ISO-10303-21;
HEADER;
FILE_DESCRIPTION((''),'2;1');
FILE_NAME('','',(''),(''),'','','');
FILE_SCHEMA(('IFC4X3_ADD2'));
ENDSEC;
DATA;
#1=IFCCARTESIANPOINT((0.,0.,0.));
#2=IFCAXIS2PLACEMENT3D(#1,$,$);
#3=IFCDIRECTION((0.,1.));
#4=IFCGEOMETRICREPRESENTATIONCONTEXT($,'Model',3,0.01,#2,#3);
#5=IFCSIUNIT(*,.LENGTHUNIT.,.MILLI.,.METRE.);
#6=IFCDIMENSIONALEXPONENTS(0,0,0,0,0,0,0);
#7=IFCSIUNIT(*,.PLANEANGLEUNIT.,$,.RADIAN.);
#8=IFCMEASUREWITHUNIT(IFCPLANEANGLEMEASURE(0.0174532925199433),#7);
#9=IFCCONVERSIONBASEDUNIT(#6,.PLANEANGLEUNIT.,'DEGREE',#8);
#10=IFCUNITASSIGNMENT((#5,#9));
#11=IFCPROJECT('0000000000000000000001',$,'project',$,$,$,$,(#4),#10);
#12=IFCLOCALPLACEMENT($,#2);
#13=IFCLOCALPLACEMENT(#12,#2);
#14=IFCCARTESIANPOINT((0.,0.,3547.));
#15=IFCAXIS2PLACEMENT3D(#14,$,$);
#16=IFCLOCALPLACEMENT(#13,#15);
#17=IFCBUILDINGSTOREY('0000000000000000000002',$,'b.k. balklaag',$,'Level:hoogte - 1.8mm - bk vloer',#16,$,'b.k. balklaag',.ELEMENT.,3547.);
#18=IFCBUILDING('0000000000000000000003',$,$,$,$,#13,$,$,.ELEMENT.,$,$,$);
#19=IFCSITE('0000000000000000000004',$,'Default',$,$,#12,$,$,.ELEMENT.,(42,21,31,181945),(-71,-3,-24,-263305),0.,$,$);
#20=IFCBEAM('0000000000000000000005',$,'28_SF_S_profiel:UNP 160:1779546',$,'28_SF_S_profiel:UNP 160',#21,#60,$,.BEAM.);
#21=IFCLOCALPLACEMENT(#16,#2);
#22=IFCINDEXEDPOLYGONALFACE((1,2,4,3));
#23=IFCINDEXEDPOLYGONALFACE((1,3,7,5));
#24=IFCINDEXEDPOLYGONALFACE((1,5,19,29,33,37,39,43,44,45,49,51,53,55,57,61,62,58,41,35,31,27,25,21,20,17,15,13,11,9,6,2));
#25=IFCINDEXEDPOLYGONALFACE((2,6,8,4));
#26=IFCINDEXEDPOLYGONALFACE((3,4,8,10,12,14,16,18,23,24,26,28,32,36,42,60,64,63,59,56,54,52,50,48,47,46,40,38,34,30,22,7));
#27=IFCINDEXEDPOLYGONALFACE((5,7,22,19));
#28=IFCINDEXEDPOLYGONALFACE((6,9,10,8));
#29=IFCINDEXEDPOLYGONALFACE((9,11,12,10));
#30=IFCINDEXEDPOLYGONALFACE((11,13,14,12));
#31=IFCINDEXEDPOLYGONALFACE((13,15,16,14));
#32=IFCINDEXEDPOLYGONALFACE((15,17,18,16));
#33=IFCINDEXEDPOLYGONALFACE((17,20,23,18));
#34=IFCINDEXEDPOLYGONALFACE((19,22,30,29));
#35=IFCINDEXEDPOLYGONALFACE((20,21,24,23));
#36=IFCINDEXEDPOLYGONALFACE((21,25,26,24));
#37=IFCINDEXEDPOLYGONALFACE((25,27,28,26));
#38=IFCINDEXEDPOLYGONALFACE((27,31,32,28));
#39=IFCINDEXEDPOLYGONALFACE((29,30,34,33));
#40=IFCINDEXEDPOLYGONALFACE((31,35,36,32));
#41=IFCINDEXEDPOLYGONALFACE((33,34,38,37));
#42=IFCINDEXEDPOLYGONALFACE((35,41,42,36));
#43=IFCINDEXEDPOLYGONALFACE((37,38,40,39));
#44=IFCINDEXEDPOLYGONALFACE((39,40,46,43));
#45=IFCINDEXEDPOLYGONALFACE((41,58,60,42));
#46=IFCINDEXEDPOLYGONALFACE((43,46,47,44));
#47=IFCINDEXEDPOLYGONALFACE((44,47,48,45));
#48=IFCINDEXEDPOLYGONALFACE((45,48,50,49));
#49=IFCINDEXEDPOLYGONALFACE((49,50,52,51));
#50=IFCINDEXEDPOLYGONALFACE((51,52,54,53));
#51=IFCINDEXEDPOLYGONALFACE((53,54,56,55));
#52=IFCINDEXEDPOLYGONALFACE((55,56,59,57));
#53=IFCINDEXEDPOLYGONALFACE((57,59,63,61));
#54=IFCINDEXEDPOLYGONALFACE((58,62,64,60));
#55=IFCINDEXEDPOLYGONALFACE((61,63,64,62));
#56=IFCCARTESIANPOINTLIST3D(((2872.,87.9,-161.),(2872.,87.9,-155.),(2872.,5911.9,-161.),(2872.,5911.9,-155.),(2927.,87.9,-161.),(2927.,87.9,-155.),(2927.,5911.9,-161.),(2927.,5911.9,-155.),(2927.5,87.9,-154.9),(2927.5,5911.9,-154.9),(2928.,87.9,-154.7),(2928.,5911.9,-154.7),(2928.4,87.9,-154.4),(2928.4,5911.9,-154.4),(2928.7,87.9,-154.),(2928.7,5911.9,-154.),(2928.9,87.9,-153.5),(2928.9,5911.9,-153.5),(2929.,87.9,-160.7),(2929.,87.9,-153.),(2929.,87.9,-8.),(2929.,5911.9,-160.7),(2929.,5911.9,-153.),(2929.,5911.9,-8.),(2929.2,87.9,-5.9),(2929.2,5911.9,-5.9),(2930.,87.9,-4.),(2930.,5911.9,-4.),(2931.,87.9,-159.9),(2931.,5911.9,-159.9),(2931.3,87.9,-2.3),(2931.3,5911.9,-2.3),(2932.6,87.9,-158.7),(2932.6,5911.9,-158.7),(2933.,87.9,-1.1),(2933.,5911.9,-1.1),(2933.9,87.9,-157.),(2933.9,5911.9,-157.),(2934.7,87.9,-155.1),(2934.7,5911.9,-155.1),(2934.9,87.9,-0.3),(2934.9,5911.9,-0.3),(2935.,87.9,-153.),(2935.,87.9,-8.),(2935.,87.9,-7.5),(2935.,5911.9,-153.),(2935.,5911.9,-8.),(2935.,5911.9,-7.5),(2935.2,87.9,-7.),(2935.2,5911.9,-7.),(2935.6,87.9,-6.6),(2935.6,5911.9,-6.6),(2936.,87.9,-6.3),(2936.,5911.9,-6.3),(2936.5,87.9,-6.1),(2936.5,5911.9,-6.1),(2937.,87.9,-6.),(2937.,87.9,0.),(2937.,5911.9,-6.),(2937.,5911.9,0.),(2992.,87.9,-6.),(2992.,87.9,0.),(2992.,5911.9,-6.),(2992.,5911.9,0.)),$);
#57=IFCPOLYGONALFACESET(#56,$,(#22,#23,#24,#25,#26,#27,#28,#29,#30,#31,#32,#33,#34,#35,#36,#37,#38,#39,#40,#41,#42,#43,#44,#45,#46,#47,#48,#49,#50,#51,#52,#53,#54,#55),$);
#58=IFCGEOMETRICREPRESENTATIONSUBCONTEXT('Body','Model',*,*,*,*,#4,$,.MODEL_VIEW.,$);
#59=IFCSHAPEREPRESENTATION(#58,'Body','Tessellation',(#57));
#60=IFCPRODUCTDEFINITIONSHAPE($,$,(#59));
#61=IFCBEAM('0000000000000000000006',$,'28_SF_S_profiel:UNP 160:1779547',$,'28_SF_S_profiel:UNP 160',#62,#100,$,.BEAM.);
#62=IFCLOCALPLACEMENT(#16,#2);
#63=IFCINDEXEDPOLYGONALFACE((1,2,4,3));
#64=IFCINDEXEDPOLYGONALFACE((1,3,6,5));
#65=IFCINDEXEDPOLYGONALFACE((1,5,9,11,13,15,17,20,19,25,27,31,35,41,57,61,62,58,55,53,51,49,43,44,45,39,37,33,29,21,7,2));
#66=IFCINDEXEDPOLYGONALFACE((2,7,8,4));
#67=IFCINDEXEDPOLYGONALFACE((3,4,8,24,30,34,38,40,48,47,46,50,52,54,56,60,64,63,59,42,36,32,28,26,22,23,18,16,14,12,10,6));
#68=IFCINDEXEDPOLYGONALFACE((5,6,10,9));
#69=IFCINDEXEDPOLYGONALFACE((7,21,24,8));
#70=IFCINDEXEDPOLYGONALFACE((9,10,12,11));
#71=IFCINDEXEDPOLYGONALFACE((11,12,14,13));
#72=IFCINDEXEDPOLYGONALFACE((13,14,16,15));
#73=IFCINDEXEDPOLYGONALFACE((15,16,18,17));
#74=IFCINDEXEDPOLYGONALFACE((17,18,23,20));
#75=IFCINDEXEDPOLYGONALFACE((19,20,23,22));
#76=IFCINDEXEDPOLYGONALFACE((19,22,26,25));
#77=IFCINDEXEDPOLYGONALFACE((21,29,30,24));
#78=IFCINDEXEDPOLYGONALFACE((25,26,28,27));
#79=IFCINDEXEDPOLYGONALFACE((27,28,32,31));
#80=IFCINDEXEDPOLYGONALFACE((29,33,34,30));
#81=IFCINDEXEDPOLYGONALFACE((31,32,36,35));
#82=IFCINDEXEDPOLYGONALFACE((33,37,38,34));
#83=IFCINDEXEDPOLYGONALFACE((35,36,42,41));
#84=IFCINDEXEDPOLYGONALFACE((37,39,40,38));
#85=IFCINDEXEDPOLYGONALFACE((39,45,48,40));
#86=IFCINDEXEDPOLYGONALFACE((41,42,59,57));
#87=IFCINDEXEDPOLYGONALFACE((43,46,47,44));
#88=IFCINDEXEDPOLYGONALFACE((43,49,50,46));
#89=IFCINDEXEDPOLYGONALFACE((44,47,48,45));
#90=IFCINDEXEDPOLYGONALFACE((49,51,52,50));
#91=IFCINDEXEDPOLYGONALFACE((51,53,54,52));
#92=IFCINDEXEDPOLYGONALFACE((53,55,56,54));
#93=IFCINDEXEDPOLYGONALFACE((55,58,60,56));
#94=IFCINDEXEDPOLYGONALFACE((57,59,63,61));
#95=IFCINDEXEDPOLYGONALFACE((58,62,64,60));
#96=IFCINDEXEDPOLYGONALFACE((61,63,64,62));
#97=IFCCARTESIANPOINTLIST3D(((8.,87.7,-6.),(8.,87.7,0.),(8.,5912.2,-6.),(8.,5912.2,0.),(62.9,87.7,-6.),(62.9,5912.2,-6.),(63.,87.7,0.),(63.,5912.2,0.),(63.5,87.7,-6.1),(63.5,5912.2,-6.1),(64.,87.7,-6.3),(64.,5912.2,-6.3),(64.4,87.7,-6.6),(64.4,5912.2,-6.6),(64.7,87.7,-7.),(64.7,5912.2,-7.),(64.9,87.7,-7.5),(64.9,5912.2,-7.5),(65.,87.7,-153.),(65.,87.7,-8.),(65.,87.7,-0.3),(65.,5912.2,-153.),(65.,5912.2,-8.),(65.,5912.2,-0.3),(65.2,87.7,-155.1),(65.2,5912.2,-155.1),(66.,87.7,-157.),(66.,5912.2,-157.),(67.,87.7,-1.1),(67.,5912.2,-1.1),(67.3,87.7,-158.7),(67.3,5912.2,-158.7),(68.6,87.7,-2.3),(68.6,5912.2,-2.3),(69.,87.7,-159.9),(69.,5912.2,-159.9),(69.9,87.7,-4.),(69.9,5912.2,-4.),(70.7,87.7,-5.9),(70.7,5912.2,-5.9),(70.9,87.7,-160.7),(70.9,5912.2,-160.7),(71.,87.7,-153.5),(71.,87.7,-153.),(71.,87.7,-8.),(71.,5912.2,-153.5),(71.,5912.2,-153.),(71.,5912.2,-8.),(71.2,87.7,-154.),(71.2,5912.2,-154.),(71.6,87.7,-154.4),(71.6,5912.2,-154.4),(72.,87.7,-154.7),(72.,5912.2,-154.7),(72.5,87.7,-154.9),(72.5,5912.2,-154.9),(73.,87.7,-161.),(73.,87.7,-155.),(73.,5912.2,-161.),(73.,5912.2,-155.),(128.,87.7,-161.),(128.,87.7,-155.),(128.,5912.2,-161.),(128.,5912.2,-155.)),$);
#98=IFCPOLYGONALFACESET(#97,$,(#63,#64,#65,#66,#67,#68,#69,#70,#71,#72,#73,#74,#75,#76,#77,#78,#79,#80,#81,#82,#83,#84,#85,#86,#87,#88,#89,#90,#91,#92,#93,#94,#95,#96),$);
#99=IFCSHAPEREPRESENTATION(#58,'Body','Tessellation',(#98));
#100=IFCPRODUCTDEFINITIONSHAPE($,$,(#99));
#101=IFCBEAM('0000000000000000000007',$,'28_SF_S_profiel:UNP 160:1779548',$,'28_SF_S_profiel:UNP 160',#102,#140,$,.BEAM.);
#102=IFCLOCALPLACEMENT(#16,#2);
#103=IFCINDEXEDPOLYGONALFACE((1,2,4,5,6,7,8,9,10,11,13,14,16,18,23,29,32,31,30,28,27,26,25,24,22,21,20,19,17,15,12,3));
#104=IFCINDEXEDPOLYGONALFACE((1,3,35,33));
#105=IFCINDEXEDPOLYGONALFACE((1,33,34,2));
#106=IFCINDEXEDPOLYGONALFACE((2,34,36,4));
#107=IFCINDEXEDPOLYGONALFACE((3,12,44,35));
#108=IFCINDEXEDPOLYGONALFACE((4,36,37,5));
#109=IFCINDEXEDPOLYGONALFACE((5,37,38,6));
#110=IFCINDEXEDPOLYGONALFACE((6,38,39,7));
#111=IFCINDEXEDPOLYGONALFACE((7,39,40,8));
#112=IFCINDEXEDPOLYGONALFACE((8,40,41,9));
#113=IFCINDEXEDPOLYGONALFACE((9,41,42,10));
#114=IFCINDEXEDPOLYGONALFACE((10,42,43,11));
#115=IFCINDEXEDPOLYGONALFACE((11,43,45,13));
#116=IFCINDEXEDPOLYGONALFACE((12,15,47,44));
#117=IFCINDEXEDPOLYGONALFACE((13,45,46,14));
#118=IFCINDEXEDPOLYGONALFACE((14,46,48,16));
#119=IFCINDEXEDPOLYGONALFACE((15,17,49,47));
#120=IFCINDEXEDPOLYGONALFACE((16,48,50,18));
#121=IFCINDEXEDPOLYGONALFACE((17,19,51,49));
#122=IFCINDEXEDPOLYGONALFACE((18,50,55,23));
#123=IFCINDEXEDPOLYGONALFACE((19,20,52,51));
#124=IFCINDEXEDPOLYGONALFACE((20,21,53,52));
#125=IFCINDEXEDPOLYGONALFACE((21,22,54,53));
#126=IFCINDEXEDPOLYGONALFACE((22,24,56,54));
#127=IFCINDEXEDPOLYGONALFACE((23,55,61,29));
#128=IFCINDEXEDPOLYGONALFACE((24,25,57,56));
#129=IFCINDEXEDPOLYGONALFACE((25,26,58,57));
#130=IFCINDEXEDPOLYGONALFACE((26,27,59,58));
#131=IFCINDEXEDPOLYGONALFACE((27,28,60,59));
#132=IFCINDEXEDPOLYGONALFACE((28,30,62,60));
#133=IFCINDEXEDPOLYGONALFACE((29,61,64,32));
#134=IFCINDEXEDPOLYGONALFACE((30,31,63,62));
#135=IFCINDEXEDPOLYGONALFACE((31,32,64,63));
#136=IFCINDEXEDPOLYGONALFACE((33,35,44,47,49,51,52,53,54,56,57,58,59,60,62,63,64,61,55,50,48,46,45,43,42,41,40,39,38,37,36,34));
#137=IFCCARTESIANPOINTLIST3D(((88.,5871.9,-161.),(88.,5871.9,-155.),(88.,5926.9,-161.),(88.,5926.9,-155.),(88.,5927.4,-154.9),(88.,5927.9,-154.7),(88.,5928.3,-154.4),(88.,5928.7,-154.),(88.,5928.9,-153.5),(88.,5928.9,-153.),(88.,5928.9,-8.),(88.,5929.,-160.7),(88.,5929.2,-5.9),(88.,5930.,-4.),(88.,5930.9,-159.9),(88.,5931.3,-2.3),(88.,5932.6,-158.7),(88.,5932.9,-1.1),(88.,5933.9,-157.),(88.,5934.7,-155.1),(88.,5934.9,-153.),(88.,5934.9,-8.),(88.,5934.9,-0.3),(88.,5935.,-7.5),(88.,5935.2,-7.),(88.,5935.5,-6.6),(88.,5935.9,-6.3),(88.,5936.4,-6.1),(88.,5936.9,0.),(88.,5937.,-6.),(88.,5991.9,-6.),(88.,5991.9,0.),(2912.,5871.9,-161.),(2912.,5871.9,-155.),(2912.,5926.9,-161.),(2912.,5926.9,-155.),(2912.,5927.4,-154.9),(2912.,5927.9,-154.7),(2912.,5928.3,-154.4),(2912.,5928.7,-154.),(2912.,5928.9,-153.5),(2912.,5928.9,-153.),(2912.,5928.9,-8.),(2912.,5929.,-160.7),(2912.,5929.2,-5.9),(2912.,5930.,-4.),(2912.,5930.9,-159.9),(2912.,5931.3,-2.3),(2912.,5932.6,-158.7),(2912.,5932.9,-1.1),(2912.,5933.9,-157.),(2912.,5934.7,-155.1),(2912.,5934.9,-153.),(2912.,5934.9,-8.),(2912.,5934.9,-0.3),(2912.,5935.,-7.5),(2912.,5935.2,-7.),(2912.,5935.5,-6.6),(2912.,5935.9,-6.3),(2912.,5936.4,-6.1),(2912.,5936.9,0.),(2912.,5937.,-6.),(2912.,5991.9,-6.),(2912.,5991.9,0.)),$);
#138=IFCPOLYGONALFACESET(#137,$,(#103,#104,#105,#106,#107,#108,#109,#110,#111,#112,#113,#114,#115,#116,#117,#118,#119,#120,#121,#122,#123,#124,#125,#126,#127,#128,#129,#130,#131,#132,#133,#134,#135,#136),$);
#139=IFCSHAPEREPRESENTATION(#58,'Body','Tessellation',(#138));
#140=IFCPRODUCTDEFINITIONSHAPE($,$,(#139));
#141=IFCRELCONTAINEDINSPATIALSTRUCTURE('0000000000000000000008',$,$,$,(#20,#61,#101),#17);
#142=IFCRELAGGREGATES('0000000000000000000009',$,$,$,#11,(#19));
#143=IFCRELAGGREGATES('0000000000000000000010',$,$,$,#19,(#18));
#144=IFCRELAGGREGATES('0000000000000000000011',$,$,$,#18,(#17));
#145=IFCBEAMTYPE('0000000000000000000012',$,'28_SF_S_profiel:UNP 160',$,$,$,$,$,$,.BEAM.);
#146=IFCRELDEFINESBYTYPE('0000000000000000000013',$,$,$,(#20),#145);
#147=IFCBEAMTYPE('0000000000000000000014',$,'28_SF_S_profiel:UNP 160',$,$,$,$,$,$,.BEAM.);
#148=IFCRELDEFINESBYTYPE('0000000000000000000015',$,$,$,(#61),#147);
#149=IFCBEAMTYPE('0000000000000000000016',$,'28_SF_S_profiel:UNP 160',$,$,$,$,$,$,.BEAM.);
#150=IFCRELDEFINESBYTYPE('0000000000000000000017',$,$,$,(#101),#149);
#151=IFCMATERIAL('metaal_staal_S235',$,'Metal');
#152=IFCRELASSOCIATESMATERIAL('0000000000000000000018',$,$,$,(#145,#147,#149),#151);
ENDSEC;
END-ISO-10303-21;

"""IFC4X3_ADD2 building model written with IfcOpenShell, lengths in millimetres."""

from ifc_helpers import new_model, entity, si_unit, converted_unit, direction, frame, frame_2d, origin, place, context, subcontext, project, spatial, polyline, circle_curve, parameter, trimmed, segment, composite_curve, outline, extrude, source, transform, mapped, material, material_profile, profile_set, type_object, type_shapes, element, save


model = new_model("IFC4X3_ADD2")

# Units and contexts
model_context = context("Model", 3, precision=0.01, world=origin(), true_north=direction((0.0, 1.0)))
body_context = subcontext(model_context, "Body", "Model", "MODEL_VIEW")
ifc_project = project(units=[si_unit("LENGTHUNIT", "METRE", prefix="MILLI"), converted_unit("PLANEANGLEUNIT", "DEGREE", entity("IfcPlaneAngleMeasure", 0.0174532925199433), si_unit("PLANEANGLEUNIT", "RADIAN"), dimensions=[0, 0, 0, 0, 0, 0, 0])], contexts=[model_context])

# Site, building, storey
site_placement = place(None, origin())
site = spatial("IfcSite", under=ifc_project, at=site_placement, Name="Default", CompositionType="ELEMENT", RefLatitude=(42, 21, 31, 181945), RefLongitude=(-71, -3, -24, -263305), RefElevation=0.0)
building_placement = place(site_placement, origin())
building = spatial("IfcBuilding", under=site, at=building_placement, CompositionType="ELEMENT")
storey_placement = place(building_placement, frame((0.0, 0.0, 3547.0)))
storey = spatial("IfcBuildingStorey", under=building, at=storey_placement, Name="b.k. balklaag", ObjectType="Level:hoogte - 1.8mm - bk vloer", LongName="b.k. balklaag", CompositionType="ELEMENT", Elevation=3547.0)

# Beams
ifc_material_1 = material(Name="metaal_staal_S235", Category="Metal")
ifc_material_profile_1 = material_profile(ifc_material_1, outline(composite_curve([segment(polyline([(-80.5, -60.0), (-74.5, -60.0)]), True, "CONTINUOUS"), segment(polyline([(-74.5, -60.0), (-74.5, -5.0)]), True, "CONTINUOUS"), segment(trimmed(circle_curve(frame_2d((-72.5, -5.0), x_axis=(0.0, -1.0)), 2.0), [parameter(180.0)], [parameter(270.0)], True, "PARAMETER"), False, "CONTINUOUS"), segment(polyline([(-72.5, -3.0), (72.5, -3.0)]), True, "CONTINUOUS"), segment(trimmed(circle_curve(frame_2d((72.5, 5.0), x_axis=(0.0, -1.0)), 8.0), [parameter(0.0)], [parameter(90.0)], True, "PARAMETER"), True, "CONTINUOUS"), segment(polyline([(80.5, 5.0), (80.5, 60.0)]), True, "CONTINUOUS"), segment(polyline([(80.5, 60.0), (74.5, 60.0)]), True, "CONTINUOUS"), segment(polyline([(74.5, 60.0), (74.5, 5.0)]), True, "CONTINUOUS"), segment(trimmed(circle_curve(frame_2d((72.5, 5.0), x_axis=(0.0, -1.0)), 2.0), [parameter(0.0)], [parameter(90.0)], True, "PARAMETER"), False, "CONTINUOUS"), segment(polyline([(72.5, 3.0), (-72.5, 3.0)]), True, "CONTINUOUS"), segment(trimmed(circle_curve(frame_2d((-72.5, -5.0), x_axis=(0.0, -1.0)), 8.0), [parameter(180.0)], [parameter(270.0)], True, "PARAMETER"), True, "CONTINUOUS"), segment(polyline([(-80.5, -5.0), (-80.5, -60.0)]), True, "CONTINUOUS")], self_intersect=False)), Name="UNP 160")
ifc_profile_set_1 = profile_set([ifc_material_profile_1], Name="UNP 160")
beam_type_1 = type_object("IfcBeamType", Name="28_SF_S_profiel:UNP 160", PredefinedType="BEAM", material=ifc_profile_set_1)
shared_shape_1 = source(origin(), body_context, "Body", "SweptSolid", [
    extrude(outline(composite_curve([segment(polyline([(-80.5, -60.0), (-74.5, -60.0)]), True, "CONTINUOUS"), segment(polyline([(-74.5, -60.0), (-74.5, -5.0)]), True, "CONTINUOUS"), segment(trimmed(circle_curve(frame_2d((-72.5, -5.0), x_axis=(0.0, -1.0)), 2.0), [parameter(180.0)], [parameter(270.0)], True, "PARAMETER"), False, "CONTINUOUS"), segment(polyline([(-72.5, -3.0), (72.5, -3.0)]), True, "CONTINUOUS"), segment(trimmed(circle_curve(frame_2d((72.5, 5.0), x_axis=(0.0, -1.0)), 8.0), [parameter(0.0)], [parameter(90.0)], True, "PARAMETER"), True, "CONTINUOUS"), segment(polyline([(80.5, 5.0), (80.5, 60.0)]), True, "CONTINUOUS"), segment(polyline([(80.5, 60.0), (74.5, 60.0)]), True, "CONTINUOUS"), segment(polyline([(74.5, 60.0), (74.5, 5.0)]), True, "CONTINUOUS"), segment(trimmed(circle_curve(frame_2d((72.5, 5.0), x_axis=(0.0, -1.0)), 2.0), [parameter(0.0)], [parameter(90.0)], True, "PARAMETER"), False, "CONTINUOUS"), segment(polyline([(72.5, 3.0), (-72.5, 3.0)]), True, "CONTINUOUS"), segment(trimmed(circle_curve(frame_2d((-72.5, -5.0), x_axis=(0.0, -1.0)), 8.0), [parameter(180.0)], [parameter(270.0)], True, "PARAMETER"), True, "CONTINUOUS"), segment(polyline([(-80.5, -5.0), (-80.5, -60.0)]), True, "CONTINUOUS")], self_intersect=False)), frame((-2912.0, 49.0, -4.5), z_axis=(1.0, 0.0, 0.0), x_axis=(0.0, 0.0, -1.0)), (0.0, 0.0, 1.0), 5824.0),
])
type_shapes(beam_type_1, [shared_shape_1])
beam_1_placement = place(storey_placement, frame((2981.0, 2999.9, -76.0), z_axis=(0.0, 0.0, 1.0), x_axis=(0.0, 1.0, 0.0)))
element("IfcBeam", 1, at=beam_1_placement, inside=storey, type_object=beam_type_1, Name="28_SF_S_profiel:UNP 160:1779546", ObjectType="28_SF_S_profiel:UNP 160", PredefinedType="BEAM", context=body_context, shape_type="MappedRepresentation", body=[
    mapped(shared_shape_1, transform((0.0, 0.0, 0.0), scale=1.0)),
])
beam_type_2 = type_object("IfcBeamType", Name="28_SF_S_profiel:UNP 160", PredefinedType="BEAM", material=ifc_profile_set_1)
shared_shape_2 = source(origin(), body_context, "Body", "SweptSolid", [
    extrude(outline(composite_curve([segment(polyline([(-60.0, -80.5), (-5.0, -80.5)]), True, "CONTINUOUS"), segment(trimmed(circle_curve(frame_2d((-5.0, -72.5), x_axis=(-1.0, 0.0)), 8.0), [parameter(90.0)], [parameter(180.0)], True, "PARAMETER"), True, "CONTINUOUS"), segment(polyline([(3.0, -72.5), (3.0, 72.5)]), True, "CONTINUOUS"), segment(trimmed(circle_curve(frame_2d((5.0, 72.5), x_axis=(-1.0, 0.0)), 2.0), [parameter(270.0)], [parameter(0.0)], True, "PARAMETER"), False, "CONTINUOUS"), segment(polyline([(5.0, 74.5), (60.0, 74.5)]), True, "CONTINUOUS"), segment(polyline([(60.0, 74.5), (60.0, 80.5)]), True, "CONTINUOUS"), segment(polyline([(60.0, 80.5), (5.0, 80.5)]), True, "CONTINUOUS"), segment(trimmed(circle_curve(frame_2d((5.0, 72.5), x_axis=(-1.0, 0.0)), 8.0), [parameter(270.0)], [parameter(0.0)], True, "PARAMETER"), True, "CONTINUOUS"), segment(polyline([(-3.0, 72.5), (-3.0, -72.5)]), True, "CONTINUOUS"), segment(trimmed(circle_curve(frame_2d((-5.0, -72.5), x_axis=(-1.0, 0.0)), 2.0), [parameter(90.0)], [parameter(180.0)], True, "PARAMETER"), False, "CONTINUOUS"), segment(polyline([(-5.0, -74.5), (-60.0, -74.5)]), True, "CONTINUOUS"), segment(polyline([(-60.0, -74.5), (-60.0, -80.5)]), True, "CONTINUOUS")], self_intersect=False)), frame((-2912.0, -49.0, -4.5), z_axis=(1.0, 0.0, 0.0), x_axis=(0.0, -1.0, 0.0)), (0.0, 0.0, 1.0), 5824.5),
])
type_shapes(beam_type_2, [shared_shape_2])
beam_2_placement = place(storey_placement, frame((19.0, 2999.7, -76.0), z_axis=(0.0, 0.0, 1.0), x_axis=(0.0, 1.0, 0.0)))
element("IfcBeam", 2, at=beam_2_placement, inside=storey, type_object=beam_type_2, Name="28_SF_S_profiel:UNP 160:1779547", ObjectType="28_SF_S_profiel:UNP 160", PredefinedType="BEAM", context=body_context, shape_type="MappedRepresentation", body=[
    mapped(shared_shape_2, transform((0.0, 0.0, 0.0), scale=1.0)),
])
beam_type_3 = type_object("IfcBeamType", Name="28_SF_S_profiel:UNP 160", PredefinedType="BEAM", material=ifc_profile_set_1)
shared_shape_3 = source(origin(), body_context, "Body", "SweptSolid", [
    extrude(outline(composite_curve([segment(polyline([(-60.0, -80.5), (-5.0, -80.5)]), True, "CONTINUOUS"), segment(trimmed(circle_curve(frame_2d((-5.0, -72.5), x_axis=(-1.0, 0.0)), 8.0), [parameter(90.0)], [parameter(180.0)], True, "PARAMETER"), True, "CONTINUOUS"), segment(polyline([(3.0, -72.5), (3.0, 72.5)]), True, "CONTINUOUS"), segment(trimmed(circle_curve(frame_2d((5.0, 72.5), x_axis=(-1.0, 0.0)), 2.0), [parameter(270.0)], [parameter(0.0)], True, "PARAMETER"), False, "CONTINUOUS"), segment(polyline([(5.0, 74.5), (60.0, 74.5)]), True, "CONTINUOUS"), segment(polyline([(60.0, 74.5), (60.0, 80.5)]), True, "CONTINUOUS"), segment(polyline([(60.0, 80.5), (5.0, 80.5)]), True, "CONTINUOUS"), segment(trimmed(circle_curve(frame_2d((5.0, 72.5), x_axis=(-1.0, 0.0)), 8.0), [parameter(270.0)], [parameter(0.0)], True, "PARAMETER"), True, "CONTINUOUS"), segment(polyline([(-3.0, 72.5), (-3.0, -72.5)]), True, "CONTINUOUS"), segment(trimmed(circle_curve(frame_2d((-5.0, -72.5), x_axis=(-1.0, 0.0)), 2.0), [parameter(90.0)], [parameter(180.0)], True, "PARAMETER"), False, "CONTINUOUS"), segment(polyline([(-5.0, -74.5), (-60.0, -74.5)]), True, "CONTINUOUS"), segment(polyline([(-60.0, -74.5), (-60.0, -80.5)]), True, "CONTINUOUS")], self_intersect=False)), frame((-1412.0, -49.0, -4.5), z_axis=(1.0, 0.0, 0.0), x_axis=(0.0, -1.0, 0.0)), (0.0, 0.0, 1.0), 2824.0),
])
type_shapes(beam_type_3, [shared_shape_3])
beam_3_placement = place(storey_placement, frame((1500.0, 5980.9, -76.0)))
element("IfcBeam", 3, at=beam_3_placement, inside=storey, type_object=beam_type_3, Name="28_SF_S_profiel:UNP 160:1779548", ObjectType="28_SF_S_profiel:UNP 160", PredefinedType="BEAM", context=body_context, shape_type="MappedRepresentation", body=[
    mapped(shared_shape_3, transform((0.0, 0.0, 0.0), scale=1.0)),
])

save(model, "model.ifc")
